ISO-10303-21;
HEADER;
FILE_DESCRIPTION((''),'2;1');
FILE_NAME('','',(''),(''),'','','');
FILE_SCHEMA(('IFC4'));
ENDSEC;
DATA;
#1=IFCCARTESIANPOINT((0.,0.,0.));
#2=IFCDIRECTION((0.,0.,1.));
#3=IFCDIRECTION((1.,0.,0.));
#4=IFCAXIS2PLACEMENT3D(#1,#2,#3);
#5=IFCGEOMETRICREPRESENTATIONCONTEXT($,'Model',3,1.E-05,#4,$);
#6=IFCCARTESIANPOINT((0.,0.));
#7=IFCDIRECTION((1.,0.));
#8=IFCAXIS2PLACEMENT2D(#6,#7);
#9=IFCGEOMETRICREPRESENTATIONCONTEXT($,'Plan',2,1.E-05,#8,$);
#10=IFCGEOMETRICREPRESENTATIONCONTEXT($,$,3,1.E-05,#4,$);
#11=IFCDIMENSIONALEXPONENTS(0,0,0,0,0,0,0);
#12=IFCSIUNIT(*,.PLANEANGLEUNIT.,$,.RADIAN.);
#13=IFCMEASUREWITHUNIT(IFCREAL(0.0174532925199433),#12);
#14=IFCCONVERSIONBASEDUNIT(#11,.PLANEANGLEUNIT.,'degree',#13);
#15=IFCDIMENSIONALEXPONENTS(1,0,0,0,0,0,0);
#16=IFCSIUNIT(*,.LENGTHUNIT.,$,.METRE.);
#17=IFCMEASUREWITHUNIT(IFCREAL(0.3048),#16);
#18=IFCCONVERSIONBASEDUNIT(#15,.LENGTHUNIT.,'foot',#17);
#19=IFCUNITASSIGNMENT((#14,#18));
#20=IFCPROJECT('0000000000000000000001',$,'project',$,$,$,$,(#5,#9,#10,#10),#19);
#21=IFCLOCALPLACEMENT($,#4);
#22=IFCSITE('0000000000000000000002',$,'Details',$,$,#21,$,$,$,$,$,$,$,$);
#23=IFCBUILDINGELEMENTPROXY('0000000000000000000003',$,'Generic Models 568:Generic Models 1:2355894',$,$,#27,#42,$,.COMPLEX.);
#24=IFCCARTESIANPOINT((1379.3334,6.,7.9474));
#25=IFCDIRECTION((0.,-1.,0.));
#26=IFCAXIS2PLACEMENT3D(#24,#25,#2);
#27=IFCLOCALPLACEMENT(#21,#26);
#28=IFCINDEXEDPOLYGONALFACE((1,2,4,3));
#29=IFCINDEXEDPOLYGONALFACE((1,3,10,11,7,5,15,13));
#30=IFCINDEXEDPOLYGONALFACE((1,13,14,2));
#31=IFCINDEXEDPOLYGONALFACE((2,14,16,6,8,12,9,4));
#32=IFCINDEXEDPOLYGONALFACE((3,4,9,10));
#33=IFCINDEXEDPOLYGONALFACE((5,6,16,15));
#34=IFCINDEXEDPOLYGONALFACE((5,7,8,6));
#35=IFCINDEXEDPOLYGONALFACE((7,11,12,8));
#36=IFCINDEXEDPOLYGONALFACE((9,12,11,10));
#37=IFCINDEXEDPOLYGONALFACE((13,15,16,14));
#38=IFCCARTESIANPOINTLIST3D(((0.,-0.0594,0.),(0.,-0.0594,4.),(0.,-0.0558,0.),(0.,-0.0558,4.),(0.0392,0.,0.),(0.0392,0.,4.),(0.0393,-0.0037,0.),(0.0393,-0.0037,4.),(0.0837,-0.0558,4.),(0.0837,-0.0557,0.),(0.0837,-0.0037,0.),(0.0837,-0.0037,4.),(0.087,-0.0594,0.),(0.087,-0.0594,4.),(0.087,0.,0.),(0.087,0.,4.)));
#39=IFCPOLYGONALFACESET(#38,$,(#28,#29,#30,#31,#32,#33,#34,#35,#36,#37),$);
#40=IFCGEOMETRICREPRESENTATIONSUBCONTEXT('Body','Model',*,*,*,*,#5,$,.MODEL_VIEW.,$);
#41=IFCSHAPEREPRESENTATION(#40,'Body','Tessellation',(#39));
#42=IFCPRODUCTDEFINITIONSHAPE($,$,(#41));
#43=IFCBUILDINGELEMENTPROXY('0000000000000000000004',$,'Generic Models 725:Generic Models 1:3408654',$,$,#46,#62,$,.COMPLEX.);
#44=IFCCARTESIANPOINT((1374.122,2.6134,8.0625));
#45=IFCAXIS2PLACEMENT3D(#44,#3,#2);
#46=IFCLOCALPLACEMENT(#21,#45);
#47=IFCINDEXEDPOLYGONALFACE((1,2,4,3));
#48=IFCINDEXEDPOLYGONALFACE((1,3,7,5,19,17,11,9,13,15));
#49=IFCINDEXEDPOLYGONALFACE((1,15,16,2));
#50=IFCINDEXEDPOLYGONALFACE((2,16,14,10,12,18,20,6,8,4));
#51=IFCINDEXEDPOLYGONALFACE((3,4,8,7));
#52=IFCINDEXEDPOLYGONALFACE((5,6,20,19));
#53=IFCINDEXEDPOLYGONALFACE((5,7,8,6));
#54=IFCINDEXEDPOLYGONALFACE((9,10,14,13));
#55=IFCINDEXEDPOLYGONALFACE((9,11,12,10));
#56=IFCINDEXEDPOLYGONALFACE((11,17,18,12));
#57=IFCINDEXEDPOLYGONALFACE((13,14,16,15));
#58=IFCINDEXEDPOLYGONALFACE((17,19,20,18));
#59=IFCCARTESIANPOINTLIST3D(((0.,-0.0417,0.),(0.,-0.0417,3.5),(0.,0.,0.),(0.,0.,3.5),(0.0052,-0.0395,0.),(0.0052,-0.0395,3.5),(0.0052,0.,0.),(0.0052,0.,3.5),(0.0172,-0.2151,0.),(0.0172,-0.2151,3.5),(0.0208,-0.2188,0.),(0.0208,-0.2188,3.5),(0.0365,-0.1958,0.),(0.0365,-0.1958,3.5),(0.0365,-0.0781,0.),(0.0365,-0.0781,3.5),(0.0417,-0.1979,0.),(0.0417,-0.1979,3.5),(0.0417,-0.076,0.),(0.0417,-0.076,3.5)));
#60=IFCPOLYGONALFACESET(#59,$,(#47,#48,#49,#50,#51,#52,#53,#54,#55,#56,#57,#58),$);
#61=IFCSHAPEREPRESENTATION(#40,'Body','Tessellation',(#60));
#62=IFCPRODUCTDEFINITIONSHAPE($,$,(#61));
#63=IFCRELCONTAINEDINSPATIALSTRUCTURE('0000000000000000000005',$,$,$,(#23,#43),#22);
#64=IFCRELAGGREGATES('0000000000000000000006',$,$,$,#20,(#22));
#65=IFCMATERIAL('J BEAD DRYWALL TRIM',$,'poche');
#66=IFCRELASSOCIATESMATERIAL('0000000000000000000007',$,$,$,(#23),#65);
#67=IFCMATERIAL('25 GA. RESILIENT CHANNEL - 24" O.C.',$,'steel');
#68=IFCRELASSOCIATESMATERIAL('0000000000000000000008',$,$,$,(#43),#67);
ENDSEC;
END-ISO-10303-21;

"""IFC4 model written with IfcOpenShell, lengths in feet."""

from ifc_helpers import new_model, entity, si_unit, converted_unit, frame, origin_with_axes, origin_2d_with_axis, place, context, subcontext, project, spatial, polyline, line, indexed_curve, outline, extrude, material, element, save


model = new_model("IFC4")

# Units and contexts
model_context = context("Model", 3, precision=1e-05, world=origin_with_axes())
plan_context = context("Plan", 2, precision=1e-05, world=origin_2d_with_axis())
context_of_model = context(None, 3, precision=1e-05, world=origin_with_axes())
body_context = subcontext(model_context, "Body", "Model", "MODEL_VIEW")
ifc_project = project(units=[converted_unit("PLANEANGLEUNIT", "degree", entity("IfcReal", 0.0174532925199433), si_unit("PLANEANGLEUNIT", "RADIAN"), dimensions=[0, 0, 0, 0, 0, 0, 0]), converted_unit("LENGTHUNIT", "foot", entity("IfcReal", 0.3048), si_unit("LENGTHUNIT", "METRE"), dimensions=[1, 0, 0, 0, 0, 0, 0])], contexts=[model_context, plan_context, context_of_model, context_of_model])

# Site
site_placement = place(None, origin_with_axes())
site = spatial("IfcSite", under=ifc_project, at=site_placement, Name="Details")

# Building element proxies
ifc_material_1 = material(Name="J BEAD DRYWALL TRIM", Category="poche")
proxy_1_placement = place(site_placement, frame((1379.3334, 6.0, 7.9474), z_axis=(0.0, -1.0, 0.0), x_axis=(0.0, 0.0, 1.0)))
element("IfcBuildingElementProxy", 1, at=proxy_1_placement, inside=site, material=ifc_material_1, Name="Generic Models 568:Generic Models 1:2355894", PredefinedType="COMPLEX", context=body_context, shape_type="SweptSolid", body=[
    extrude(outline(polyline([(-0.0345, -0.0297), (0.0525, -0.0297), (0.0525, -0.026), (-0.0313, -0.026), (-0.0313, 0.026), (0.0132, 0.026), (0.0133, 0.0297), (-0.0345, 0.0297), (-0.0345, -0.0297)])), frame((0.0525, -0.0297, 0.0), z_axis=(0.0, 0.0, -1.0), x_axis=(-1.0, 0.0, 0.0)), (0.0, 0.0, -1.0), 4.0),
])
ifc_material_2 = material(Name="25 GA. RESILIENT CHANNEL - 24\" O.C.", Category="steel")
proxy_2_placement = place(site_placement, frame((1374.122, 2.6134, 8.0625), z_axis=(1.0, 0.0, 0.0), x_axis=(0.0, 0.0, 1.0)))
element("IfcBuildingElementProxy", 2, at=proxy_2_placement, inside=site, material=ifc_material_2, Name="Generic Models 725:Generic Models 1:3408654", PredefinedType="COMPLEX", context=body_context, shape_type="SweptSolid", body=[
    extrude(outline(indexed_curve([(0.0684, -0.0024), (0.1072, 0.0051), (0.1082, 0.0), (0.0673, -0.0079), (0.0246, 0.021), (-0.0909, -0.0012), (-0.1062, -0.0238), (-0.1105, -0.0209), (-0.094, 0.0035), (0.0258, 0.0266)], segments=[line(6, 5), line(5, 4), line(4, 3), line(3, 2), line(2, 1), line(1, 10), line(10, 9), line(9, 8), line(8, 7), line(7, 6)], self_intersect=False)), frame((0.0205, -0.1063, 0.0), z_axis=(0.0, 0.0, -1.0), x_axis=(-0.189091, 0.98196, 0.0)), (0.0, 0.0, -1.0), 3.5),
])

save(model, "model.ifc")
